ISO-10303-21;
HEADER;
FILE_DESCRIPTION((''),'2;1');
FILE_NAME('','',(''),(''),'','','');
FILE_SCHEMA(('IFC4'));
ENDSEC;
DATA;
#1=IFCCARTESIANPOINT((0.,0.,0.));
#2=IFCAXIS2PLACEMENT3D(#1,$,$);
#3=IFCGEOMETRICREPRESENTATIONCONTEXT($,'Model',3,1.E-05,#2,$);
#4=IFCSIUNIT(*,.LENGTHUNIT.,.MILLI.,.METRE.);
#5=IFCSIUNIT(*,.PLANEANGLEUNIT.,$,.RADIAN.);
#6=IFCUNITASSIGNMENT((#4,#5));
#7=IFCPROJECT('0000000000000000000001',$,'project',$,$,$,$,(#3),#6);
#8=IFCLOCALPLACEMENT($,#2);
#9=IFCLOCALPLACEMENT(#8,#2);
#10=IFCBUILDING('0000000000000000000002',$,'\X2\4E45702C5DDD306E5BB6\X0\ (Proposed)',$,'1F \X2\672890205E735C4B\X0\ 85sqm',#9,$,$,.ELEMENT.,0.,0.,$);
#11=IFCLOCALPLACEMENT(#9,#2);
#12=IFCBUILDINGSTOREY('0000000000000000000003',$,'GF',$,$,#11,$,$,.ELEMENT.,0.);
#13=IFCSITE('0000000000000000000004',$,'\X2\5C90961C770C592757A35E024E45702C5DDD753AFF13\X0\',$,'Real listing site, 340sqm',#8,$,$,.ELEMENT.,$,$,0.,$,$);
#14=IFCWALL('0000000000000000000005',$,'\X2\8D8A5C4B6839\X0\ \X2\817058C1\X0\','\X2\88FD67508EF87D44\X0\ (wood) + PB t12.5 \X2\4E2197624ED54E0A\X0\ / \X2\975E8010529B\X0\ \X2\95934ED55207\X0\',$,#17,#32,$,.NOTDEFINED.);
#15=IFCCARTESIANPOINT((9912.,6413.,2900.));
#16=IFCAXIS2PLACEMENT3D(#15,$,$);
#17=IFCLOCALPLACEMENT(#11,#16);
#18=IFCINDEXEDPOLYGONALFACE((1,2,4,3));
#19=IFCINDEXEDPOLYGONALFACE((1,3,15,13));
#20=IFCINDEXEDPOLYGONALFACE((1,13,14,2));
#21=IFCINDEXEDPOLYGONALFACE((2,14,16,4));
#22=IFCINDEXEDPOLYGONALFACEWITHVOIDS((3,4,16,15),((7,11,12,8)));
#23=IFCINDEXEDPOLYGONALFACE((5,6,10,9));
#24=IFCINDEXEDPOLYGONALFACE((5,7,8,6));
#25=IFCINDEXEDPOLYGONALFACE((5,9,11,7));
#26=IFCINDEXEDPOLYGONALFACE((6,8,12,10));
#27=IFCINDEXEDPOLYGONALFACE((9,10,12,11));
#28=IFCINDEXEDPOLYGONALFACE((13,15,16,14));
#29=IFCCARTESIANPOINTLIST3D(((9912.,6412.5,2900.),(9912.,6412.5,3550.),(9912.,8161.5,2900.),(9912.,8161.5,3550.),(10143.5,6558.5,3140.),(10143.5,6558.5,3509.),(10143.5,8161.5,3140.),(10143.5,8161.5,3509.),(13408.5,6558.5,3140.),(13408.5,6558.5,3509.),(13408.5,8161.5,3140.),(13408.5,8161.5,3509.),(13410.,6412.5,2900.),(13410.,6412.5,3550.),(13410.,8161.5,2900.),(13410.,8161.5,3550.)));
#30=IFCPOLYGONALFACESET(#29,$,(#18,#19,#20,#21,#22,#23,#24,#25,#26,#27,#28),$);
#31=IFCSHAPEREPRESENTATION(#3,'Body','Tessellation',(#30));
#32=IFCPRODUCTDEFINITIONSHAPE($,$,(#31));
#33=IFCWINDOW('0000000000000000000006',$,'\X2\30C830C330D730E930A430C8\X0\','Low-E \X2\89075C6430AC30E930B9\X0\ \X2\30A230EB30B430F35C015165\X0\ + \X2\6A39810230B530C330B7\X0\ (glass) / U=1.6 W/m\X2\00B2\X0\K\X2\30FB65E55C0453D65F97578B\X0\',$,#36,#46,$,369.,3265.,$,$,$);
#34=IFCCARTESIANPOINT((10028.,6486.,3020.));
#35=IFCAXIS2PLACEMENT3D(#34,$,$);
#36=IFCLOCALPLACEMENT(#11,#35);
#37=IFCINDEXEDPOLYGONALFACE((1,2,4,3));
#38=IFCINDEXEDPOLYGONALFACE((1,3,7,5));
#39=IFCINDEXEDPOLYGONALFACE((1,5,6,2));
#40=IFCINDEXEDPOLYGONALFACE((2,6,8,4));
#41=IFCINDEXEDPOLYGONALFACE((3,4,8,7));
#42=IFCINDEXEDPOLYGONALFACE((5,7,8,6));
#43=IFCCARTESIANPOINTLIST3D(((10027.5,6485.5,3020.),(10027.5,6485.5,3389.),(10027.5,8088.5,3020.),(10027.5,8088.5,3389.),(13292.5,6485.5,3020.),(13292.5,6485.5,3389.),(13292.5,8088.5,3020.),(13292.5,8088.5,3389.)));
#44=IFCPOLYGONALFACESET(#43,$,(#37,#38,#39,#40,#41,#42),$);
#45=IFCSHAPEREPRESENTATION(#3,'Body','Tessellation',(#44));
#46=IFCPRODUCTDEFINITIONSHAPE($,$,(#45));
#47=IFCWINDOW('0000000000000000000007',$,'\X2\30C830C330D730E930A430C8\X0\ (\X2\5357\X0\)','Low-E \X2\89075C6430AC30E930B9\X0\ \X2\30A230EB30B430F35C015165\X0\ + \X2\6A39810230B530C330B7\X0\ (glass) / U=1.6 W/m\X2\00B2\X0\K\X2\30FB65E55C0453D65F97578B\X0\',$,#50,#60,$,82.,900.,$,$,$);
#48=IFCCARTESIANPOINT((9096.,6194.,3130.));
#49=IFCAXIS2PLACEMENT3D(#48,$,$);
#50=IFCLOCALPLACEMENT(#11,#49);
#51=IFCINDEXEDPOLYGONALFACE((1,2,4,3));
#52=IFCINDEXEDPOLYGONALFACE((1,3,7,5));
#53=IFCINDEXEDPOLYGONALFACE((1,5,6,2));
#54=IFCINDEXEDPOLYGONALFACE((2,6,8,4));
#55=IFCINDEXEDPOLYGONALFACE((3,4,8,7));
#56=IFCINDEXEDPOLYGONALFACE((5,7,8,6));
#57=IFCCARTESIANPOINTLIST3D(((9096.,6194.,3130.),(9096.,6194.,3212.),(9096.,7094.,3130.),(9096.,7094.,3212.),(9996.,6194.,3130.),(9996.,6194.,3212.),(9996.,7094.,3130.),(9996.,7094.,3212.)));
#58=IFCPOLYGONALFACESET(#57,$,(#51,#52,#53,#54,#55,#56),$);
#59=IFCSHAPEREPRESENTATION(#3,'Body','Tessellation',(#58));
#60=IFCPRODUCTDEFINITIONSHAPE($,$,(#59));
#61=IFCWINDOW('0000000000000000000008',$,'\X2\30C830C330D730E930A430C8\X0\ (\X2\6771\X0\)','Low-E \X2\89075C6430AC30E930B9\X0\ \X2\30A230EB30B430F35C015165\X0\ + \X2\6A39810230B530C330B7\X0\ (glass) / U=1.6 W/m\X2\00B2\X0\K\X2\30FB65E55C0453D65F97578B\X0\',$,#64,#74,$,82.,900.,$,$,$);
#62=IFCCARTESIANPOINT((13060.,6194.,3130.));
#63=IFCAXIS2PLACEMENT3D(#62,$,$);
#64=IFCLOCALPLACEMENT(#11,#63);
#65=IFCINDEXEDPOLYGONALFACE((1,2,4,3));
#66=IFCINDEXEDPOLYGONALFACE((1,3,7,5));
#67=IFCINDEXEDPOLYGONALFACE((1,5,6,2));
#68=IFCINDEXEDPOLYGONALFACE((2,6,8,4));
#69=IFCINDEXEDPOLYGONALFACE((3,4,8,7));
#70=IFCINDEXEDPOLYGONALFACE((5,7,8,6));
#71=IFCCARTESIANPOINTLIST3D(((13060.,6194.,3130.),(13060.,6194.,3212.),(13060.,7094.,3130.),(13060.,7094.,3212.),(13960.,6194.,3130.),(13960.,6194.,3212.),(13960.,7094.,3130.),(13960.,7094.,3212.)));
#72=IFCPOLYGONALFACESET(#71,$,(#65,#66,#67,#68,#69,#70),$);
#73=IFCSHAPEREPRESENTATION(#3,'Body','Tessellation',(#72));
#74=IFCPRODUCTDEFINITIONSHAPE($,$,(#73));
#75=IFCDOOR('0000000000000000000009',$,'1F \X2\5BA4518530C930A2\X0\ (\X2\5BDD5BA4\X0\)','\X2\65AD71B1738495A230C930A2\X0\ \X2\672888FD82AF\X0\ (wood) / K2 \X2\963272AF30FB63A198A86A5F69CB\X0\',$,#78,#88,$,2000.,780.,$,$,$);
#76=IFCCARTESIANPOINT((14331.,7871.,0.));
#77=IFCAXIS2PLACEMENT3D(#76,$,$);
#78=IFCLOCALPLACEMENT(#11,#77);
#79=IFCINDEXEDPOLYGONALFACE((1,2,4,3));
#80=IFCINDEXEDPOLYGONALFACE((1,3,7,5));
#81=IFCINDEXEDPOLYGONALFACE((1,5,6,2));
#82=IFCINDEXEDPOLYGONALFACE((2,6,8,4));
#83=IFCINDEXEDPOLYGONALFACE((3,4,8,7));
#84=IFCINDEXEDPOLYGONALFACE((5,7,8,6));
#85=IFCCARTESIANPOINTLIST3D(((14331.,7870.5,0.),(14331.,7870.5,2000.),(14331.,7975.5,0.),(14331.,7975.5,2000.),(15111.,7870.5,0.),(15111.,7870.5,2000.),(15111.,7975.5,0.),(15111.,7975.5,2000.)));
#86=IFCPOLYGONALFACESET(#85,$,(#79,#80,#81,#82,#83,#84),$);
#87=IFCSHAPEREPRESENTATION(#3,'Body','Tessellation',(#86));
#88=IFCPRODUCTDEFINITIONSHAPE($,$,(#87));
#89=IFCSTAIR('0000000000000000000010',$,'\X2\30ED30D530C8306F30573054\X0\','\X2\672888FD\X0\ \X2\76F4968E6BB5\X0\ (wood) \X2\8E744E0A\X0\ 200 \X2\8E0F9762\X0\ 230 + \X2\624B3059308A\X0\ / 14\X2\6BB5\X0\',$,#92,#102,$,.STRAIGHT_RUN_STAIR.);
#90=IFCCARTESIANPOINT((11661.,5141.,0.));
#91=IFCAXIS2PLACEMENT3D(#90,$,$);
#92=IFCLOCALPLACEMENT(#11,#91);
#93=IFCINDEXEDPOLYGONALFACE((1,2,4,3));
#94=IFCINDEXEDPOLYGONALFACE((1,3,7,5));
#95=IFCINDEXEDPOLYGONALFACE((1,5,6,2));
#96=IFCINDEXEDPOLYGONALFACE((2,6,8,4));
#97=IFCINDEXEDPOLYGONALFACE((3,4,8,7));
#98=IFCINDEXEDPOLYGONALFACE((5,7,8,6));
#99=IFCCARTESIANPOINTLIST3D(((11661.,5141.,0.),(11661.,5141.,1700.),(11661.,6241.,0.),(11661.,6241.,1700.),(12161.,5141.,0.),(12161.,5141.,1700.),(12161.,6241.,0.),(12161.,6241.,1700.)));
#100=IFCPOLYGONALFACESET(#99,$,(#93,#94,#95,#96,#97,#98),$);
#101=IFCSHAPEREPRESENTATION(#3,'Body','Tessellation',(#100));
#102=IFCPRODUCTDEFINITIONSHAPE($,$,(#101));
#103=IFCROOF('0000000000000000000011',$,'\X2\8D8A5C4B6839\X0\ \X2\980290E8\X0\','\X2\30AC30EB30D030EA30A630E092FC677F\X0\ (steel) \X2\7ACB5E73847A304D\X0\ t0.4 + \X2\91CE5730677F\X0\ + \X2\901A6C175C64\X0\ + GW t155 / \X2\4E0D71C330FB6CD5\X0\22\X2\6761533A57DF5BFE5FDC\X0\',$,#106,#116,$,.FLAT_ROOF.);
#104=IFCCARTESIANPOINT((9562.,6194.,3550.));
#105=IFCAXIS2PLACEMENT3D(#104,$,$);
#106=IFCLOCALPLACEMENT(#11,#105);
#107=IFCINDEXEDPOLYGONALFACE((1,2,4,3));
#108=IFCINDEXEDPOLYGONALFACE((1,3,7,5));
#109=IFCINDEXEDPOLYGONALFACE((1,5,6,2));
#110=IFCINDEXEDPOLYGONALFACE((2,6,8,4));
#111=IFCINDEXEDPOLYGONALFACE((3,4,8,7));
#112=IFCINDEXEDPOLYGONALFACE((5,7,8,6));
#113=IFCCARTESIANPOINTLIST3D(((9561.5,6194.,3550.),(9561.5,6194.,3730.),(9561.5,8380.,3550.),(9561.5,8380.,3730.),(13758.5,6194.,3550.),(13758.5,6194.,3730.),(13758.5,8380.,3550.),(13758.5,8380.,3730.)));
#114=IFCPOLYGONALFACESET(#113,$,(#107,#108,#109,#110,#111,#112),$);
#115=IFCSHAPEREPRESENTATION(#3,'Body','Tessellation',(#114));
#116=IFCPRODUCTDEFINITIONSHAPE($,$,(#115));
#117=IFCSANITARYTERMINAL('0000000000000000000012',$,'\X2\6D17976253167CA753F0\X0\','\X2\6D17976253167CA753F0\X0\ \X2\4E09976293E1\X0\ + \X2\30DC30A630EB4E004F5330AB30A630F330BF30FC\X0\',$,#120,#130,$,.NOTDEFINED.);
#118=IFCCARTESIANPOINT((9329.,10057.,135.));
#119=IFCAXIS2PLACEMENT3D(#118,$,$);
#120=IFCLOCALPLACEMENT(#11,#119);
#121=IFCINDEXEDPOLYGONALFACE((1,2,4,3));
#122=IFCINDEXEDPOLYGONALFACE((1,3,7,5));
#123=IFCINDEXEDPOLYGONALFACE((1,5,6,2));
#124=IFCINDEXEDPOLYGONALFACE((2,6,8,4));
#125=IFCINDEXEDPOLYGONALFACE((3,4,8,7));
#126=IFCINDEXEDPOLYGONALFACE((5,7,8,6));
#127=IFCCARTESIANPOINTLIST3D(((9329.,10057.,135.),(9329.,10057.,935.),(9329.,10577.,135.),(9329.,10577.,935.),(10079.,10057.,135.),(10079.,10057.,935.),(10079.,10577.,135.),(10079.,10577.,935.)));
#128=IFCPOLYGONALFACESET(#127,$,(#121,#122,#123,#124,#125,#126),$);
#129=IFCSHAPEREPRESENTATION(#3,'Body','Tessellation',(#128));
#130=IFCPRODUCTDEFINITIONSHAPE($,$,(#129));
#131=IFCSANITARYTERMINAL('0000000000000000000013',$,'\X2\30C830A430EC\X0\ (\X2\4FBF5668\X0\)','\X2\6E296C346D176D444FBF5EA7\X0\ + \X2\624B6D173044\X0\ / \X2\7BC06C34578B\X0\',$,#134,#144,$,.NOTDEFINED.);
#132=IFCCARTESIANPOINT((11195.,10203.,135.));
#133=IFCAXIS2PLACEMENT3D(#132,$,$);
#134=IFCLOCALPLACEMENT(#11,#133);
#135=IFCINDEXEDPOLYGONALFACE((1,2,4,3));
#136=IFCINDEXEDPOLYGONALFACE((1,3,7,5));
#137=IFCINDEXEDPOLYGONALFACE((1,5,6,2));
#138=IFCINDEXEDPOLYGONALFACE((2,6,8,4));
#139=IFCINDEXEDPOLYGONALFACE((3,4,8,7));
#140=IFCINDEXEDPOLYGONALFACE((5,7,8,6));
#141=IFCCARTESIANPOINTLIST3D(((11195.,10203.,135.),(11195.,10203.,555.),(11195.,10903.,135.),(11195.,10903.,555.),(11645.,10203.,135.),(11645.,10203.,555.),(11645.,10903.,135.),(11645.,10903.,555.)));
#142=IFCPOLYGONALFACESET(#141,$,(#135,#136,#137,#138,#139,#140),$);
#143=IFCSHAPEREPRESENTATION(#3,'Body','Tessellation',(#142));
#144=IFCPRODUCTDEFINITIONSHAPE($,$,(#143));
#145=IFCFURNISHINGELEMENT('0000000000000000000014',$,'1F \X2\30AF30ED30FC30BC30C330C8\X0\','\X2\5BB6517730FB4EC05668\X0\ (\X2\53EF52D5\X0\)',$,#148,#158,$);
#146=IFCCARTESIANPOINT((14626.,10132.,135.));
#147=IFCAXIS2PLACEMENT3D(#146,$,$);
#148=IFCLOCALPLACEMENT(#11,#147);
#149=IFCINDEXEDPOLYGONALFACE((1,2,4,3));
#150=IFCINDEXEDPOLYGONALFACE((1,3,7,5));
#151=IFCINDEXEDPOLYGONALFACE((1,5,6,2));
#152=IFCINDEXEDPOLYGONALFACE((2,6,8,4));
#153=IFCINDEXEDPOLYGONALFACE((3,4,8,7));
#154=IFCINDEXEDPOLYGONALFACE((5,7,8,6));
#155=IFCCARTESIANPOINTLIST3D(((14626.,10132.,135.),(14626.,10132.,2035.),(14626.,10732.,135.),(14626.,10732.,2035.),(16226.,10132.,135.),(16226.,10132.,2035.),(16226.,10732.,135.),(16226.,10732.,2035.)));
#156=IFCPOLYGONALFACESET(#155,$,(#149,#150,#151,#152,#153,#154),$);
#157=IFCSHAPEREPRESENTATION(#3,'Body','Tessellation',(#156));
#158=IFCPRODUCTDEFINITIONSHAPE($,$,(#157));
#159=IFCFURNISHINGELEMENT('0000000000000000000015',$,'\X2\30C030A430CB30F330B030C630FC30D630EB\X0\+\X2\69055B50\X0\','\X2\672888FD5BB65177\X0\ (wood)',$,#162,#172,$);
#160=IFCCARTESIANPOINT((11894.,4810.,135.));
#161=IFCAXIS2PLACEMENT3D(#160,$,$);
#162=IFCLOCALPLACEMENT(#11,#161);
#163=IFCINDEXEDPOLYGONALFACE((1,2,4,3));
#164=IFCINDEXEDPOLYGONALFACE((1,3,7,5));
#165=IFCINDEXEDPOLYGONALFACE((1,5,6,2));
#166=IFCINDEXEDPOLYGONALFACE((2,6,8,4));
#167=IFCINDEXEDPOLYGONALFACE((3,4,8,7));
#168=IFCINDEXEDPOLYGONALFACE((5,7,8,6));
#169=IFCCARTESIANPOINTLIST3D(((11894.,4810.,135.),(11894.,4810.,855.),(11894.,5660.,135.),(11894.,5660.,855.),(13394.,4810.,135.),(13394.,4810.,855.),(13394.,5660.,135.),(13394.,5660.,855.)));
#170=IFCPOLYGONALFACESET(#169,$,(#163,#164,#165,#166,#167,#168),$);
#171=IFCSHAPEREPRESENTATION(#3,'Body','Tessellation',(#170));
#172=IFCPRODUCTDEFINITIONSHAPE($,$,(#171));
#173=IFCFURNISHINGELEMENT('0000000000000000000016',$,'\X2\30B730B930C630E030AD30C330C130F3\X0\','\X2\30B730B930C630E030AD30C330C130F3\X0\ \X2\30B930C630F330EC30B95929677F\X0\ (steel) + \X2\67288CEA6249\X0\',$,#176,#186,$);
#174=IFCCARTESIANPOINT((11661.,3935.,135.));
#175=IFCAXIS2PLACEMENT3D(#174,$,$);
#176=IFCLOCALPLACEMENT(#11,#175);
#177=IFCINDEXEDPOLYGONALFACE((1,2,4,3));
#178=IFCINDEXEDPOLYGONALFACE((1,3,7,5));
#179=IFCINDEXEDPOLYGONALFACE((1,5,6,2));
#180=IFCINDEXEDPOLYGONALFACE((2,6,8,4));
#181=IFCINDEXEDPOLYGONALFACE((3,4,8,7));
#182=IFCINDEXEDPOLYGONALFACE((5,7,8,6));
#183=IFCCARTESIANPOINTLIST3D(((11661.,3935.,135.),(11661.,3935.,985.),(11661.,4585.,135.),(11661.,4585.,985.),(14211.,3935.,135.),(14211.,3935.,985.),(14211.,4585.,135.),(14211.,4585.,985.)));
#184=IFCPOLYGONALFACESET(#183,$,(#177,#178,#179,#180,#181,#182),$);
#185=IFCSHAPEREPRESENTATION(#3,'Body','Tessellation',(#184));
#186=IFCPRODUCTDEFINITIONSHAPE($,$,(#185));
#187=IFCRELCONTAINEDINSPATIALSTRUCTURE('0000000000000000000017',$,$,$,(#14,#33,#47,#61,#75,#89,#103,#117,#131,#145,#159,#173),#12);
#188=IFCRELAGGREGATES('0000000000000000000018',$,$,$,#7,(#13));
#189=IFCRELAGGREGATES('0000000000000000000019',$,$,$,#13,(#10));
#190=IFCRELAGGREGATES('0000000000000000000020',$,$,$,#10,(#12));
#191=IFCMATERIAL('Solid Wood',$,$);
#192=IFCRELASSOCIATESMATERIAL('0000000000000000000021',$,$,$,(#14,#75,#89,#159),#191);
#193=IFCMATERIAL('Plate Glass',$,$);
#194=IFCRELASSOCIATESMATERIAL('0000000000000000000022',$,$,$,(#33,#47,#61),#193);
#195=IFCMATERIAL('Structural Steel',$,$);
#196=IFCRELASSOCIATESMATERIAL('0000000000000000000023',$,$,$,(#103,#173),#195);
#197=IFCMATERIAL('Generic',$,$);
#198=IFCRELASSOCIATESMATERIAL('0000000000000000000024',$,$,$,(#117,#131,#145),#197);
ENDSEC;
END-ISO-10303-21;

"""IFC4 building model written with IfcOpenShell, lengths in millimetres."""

from ifc_helpers import new_model, si_unit, frame, frame_2d, origin, place, context, project, spatial, rectangle, extrude, material, element, fill, save


model = new_model("IFC4")

# Units and contexts
model_context = context("Model", 3, precision=1e-05, world=origin())
ifc_project = project(units=[si_unit("LENGTHUNIT", "METRE", prefix="MILLI"), si_unit("PLANEANGLEUNIT", "RADIAN")], contexts=[model_context])

# Site, building, storey
site_placement = place(None, origin())
site = spatial("IfcSite", under=ifc_project, at=site_placement, Name="岐阜県大垣市久瀬川町３", ObjectType="Real listing site, 340sqm", CompositionType="ELEMENT", RefElevation=0.0)
building_placement = place(site_placement, origin())
building = spatial("IfcBuilding", under=site, at=building_placement, Name="久瀬川の家 (Proposed)", ObjectType="1F 木造平屋 85sqm", CompositionType="ELEMENT", ElevationOfRefHeight=0.0, ElevationOfTerrain=0.0)
storey_placement = place(building_placement, origin())
storey = spatial("IfcBuildingStorey", under=building, at=storey_placement, Name="GF", CompositionType="ELEMENT", Elevation=0.0)

# Shared definitions
ifc_material_1 = material(Name="Solid Wood")
ifc_material_2 = material(Name="Plate Glass")

# Wall, openings, windows
wall_1_placement = place(storey_placement, frame((9912.0, 6413.0, 2900.0)))
wall_1 = element("IfcWall", 1, at=wall_1_placement, inside=storey, material=ifc_material_1, Name="越屋根 腰壁", Description="製材軸組 (wood) + PB t12.5 両面仕上 / 非耐力 間仕切", PredefinedType="NOTDEFINED", context=model_context, shape_type="SweptSolid", body=[
    extrude(rectangle(XDim=3498.0, YDim=1749.0, at=frame_2d((1749.0, 874.0))), frame((9912.0, 6413.0, 2900.0)), (0.0, 0.0, 1.0), 650.0),
])
opening_1_placement = place(storey_placement, frame((10028.0, 6486.0, 3020.0)))
opening_1 = element("IfcOpeningElement", 2, at=opening_1_placement, cuts=wall_1, PredefinedType="NOTDEFINED", context=model_context, shape_type="SweptSolid", body=[
    extrude(rectangle(XDim=3265.0, YDim=1603.0, at=frame_2d((1632.0, 801.0))), frame((10028.0, 6486.0, 3020.0)), (0.0, 0.0, 1.0), 369.0),
])
opening_2_placement = place(storey_placement, frame((9096.0, 6194.0, 3130.0)))
opening_2 = element("IfcOpeningElement", 3, at=opening_2_placement, cuts=wall_1, PredefinedType="NOTDEFINED", context=model_context, shape_type="SweptSolid", body=[
    extrude(rectangle(XDim=900.0, YDim=900.0, at=frame_2d((450.0, 450.0))), frame((9096.0, 6194.0, 3130.0)), (0.0, 0.0, 1.0), 82.0),
])
opening_3_placement = place(storey_placement, frame((13060.0, 6194.0, 3130.0)))
opening_3 = element("IfcOpeningElement", 4, at=opening_3_placement, cuts=wall_1, PredefinedType="NOTDEFINED", context=model_context, shape_type="SweptSolid", body=[
    extrude(rectangle(XDim=900.0, YDim=900.0, at=frame_2d((450.0, 450.0))), frame((13060.0, 6194.0, 3130.0)), (0.0, 0.0, 1.0), 82.0),
])
window_1_placement = place(storey_placement, frame((10028.0, 6486.0, 3020.0)))
window_1 = element("IfcWindow", 5, at=window_1_placement, inside=storey, material=ifc_material_2, Name="トップライト", Description="Low-E 複層ガラス アルゴン封入 + 樹脂サッシ (glass) / U=1.6 W/m²K・日射取得型", OverallHeight=369.0, OverallWidth=3265.0, context=model_context, shape_type="SweptSolid", body=[
    extrude(rectangle(XDim=3265.0, YDim=1603.0, at=frame_2d((1632.0, 801.0))), frame((10028.0, 6486.0, 3020.0)), (0.0, 0.0, 1.0), 369.0),
])
fill(opening_1, window_1)
window_2_placement = place(storey_placement, frame((9096.0, 6194.0, 3130.0)))
window_2 = element("IfcWindow", 6, at=window_2_placement, inside=storey, material=ifc_material_2, Name="トップライト (南)", Description="Low-E 複層ガラス アルゴン封入 + 樹脂サッシ (glass) / U=1.6 W/m²K・日射取得型", OverallHeight=82.0, OverallWidth=900.0, context=model_context, shape_type="SweptSolid", body=[
    extrude(rectangle(XDim=900.0, YDim=900.0, at=frame_2d((450.0, 450.0))), frame((9096.0, 6194.0, 3130.0)), (0.0, 0.0, 1.0), 82.0),
])
fill(opening_2, window_2)
window_3_placement = place(storey_placement, frame((13060.0, 6194.0, 3130.0)))
window_3 = element("IfcWindow", 7, at=window_3_placement, inside=storey, material=ifc_material_2, Name="トップライト (東)", Description="Low-E 複層ガラス アルゴン封入 + 樹脂サッシ (glass) / U=1.6 W/m²K・日射取得型", OverallHeight=82.0, OverallWidth=900.0, context=model_context, shape_type="SweptSolid", body=[
    extrude(rectangle(XDim=900.0, YDim=900.0, at=frame_2d((450.0, 450.0))), frame((13060.0, 6194.0, 3130.0)), (0.0, 0.0, 1.0), 82.0),
])
fill(opening_3, window_3)

# Door
door_placement = place(storey_placement, frame((14331.0, 7871.0, 0.0)))
element("IfcDoor", 8, at=door_placement, inside=storey, material=ifc_material_1, Name="1F 室内ドア (寝室)", Description="断熱玄関ドア 木製芯 (wood) / K2 防犯・採風機構", OverallHeight=2000.0, OverallWidth=780.0, context=model_context, shape_type="SweptSolid", body=[
    extrude(rectangle(XDim=780.0, YDim=105.0, at=frame_2d((390.0, 52.0))), frame((14331.0, 7871.0, 0.0)), (0.0, 0.0, 1.0), 2000.0),
])

# Stair
stair_placement = place(storey_placement, frame((11661.0, 5141.0, 0.0)))
element("IfcStair", 9, at=stair_placement, inside=storey, material=ifc_material_1, Name="ロフトはしご", Description="木製 直階段 (wood) 蹴上 200 踏面 230 + 手すり / 14段", PredefinedType="STRAIGHT_RUN_STAIR", context=model_context, shape_type="SweptSolid", body=[
    extrude(rectangle(XDim=500.0, YDim=1100.0, at=frame_2d((250.0, 550.0))), frame((11661.0, 5141.0, 0.0)), (0.0, 0.0, 1.0), 1700.0),
])

# Roof
ifc_material_3 = material(Name="Structural Steel")
roof_placement = place(storey_placement, frame((9562.0, 6194.0, 3550.0)))
element("IfcRoof", 10, at=roof_placement, inside=storey, material=ifc_material_3, Name="越屋根 頂部", Description="ガルバリウム鋼板 (steel) 立平葺き t0.4 + 野地板 + 通気層 + GW t155 / 不燃・法22条区域対応", PredefinedType="FLAT_ROOF", context=model_context, shape_type="SweptSolid", body=[
    extrude(rectangle(XDim=4197.0, YDim=2186.0, at=frame_2d((2098.0, 1093.0))), frame((9562.0, 6194.0, 3550.0)), (0.0, 0.0, 1.0), 180.0),
])

# Sanitary terminals
ifc_material_4 = material(Name="Generic")
sanitary_terminal_1_placement = place(storey_placement, frame((9329.0, 10057.0, 135.0)))
element("IfcSanitaryTerminal", 11, at=sanitary_terminal_1_placement, inside=storey, material=ifc_material_4, Name="洗面化粧台", Description="洗面化粧台 三面鏡 + ボウル一体カウンター", PredefinedType="NOTDEFINED", context=model_context, shape_type="SweptSolid", body=[
    extrude(rectangle(XDim=750.0, YDim=520.0, at=frame_2d((375.0, 260.0))), frame((9329.0, 10057.0, 135.0)), (0.0, 0.0, 1.0), 800.0),
])
sanitary_terminal_2_placement = place(storey_placement, frame((11195.0, 10203.0, 135.0)))
element("IfcSanitaryTerminal", 12, at=sanitary_terminal_2_placement, inside=storey, material=ifc_material_4, Name="トイレ (便器)", Description="温水洗浄便座 + 手洗い / 節水型", PredefinedType="NOTDEFINED", context=model_context, shape_type="SweptSolid", body=[
    extrude(rectangle(XDim=450.0, YDim=700.0, at=frame_2d((225.0, 350.0))), frame((11195.0, 10203.0, 135.0)), (0.0, 0.0, 1.0), 420.0),
])

# Furnishing elements
furnishing_1_placement = place(storey_placement, frame((14626.0, 10132.0, 135.0)))
element("IfcFurnishingElement", 13, at=furnishing_1_placement, inside=storey, material=ifc_material_4, Name="1F クローゼット", Description="家具・什器 (可動)", context=model_context, shape_type="SweptSolid", body=[
    extrude(rectangle(XDim=1600.0, YDim=600.0, at=frame_2d((800.0, 300.0))), frame((14626.0, 10132.0, 135.0)), (0.0, 0.0, 1.0), 1900.0),
])
furnishing_2_placement = place(storey_placement, frame((11894.0, 4810.0, 135.0)))
element("IfcFurnishingElement", 14, at=furnishing_2_placement, inside=storey, material=ifc_material_1, Name="ダイニングテーブル+椅子", Description="木製家具 (wood)", context=model_context, shape_type="SweptSolid", body=[
    extrude(rectangle(XDim=1500.0, YDim=850.0, at=frame_2d((750.0, 425.0))), frame((11894.0, 4810.0, 135.0)), (0.0, 0.0, 1.0), 720.0),
])
furnishing_3_placement = place(storey_placement, frame((11661.0, 3935.0, 135.0)))
element("IfcFurnishingElement", 15, at=furnishing_3_placement, inside=storey, material=ifc_material_3, Name="システムキッチン", Description="システムキッチン ステンレス天板 (steel) + 木質扉", context=model_context, shape_type="SweptSolid", body=[
    extrude(rectangle(XDim=2550.0, YDim=650.0, at=frame_2d((1275.0, 325.0))), frame((11661.0, 3935.0, 135.0)), (0.0, 0.0, 1.0), 850.0),
])

save(model, "model.ifc")
